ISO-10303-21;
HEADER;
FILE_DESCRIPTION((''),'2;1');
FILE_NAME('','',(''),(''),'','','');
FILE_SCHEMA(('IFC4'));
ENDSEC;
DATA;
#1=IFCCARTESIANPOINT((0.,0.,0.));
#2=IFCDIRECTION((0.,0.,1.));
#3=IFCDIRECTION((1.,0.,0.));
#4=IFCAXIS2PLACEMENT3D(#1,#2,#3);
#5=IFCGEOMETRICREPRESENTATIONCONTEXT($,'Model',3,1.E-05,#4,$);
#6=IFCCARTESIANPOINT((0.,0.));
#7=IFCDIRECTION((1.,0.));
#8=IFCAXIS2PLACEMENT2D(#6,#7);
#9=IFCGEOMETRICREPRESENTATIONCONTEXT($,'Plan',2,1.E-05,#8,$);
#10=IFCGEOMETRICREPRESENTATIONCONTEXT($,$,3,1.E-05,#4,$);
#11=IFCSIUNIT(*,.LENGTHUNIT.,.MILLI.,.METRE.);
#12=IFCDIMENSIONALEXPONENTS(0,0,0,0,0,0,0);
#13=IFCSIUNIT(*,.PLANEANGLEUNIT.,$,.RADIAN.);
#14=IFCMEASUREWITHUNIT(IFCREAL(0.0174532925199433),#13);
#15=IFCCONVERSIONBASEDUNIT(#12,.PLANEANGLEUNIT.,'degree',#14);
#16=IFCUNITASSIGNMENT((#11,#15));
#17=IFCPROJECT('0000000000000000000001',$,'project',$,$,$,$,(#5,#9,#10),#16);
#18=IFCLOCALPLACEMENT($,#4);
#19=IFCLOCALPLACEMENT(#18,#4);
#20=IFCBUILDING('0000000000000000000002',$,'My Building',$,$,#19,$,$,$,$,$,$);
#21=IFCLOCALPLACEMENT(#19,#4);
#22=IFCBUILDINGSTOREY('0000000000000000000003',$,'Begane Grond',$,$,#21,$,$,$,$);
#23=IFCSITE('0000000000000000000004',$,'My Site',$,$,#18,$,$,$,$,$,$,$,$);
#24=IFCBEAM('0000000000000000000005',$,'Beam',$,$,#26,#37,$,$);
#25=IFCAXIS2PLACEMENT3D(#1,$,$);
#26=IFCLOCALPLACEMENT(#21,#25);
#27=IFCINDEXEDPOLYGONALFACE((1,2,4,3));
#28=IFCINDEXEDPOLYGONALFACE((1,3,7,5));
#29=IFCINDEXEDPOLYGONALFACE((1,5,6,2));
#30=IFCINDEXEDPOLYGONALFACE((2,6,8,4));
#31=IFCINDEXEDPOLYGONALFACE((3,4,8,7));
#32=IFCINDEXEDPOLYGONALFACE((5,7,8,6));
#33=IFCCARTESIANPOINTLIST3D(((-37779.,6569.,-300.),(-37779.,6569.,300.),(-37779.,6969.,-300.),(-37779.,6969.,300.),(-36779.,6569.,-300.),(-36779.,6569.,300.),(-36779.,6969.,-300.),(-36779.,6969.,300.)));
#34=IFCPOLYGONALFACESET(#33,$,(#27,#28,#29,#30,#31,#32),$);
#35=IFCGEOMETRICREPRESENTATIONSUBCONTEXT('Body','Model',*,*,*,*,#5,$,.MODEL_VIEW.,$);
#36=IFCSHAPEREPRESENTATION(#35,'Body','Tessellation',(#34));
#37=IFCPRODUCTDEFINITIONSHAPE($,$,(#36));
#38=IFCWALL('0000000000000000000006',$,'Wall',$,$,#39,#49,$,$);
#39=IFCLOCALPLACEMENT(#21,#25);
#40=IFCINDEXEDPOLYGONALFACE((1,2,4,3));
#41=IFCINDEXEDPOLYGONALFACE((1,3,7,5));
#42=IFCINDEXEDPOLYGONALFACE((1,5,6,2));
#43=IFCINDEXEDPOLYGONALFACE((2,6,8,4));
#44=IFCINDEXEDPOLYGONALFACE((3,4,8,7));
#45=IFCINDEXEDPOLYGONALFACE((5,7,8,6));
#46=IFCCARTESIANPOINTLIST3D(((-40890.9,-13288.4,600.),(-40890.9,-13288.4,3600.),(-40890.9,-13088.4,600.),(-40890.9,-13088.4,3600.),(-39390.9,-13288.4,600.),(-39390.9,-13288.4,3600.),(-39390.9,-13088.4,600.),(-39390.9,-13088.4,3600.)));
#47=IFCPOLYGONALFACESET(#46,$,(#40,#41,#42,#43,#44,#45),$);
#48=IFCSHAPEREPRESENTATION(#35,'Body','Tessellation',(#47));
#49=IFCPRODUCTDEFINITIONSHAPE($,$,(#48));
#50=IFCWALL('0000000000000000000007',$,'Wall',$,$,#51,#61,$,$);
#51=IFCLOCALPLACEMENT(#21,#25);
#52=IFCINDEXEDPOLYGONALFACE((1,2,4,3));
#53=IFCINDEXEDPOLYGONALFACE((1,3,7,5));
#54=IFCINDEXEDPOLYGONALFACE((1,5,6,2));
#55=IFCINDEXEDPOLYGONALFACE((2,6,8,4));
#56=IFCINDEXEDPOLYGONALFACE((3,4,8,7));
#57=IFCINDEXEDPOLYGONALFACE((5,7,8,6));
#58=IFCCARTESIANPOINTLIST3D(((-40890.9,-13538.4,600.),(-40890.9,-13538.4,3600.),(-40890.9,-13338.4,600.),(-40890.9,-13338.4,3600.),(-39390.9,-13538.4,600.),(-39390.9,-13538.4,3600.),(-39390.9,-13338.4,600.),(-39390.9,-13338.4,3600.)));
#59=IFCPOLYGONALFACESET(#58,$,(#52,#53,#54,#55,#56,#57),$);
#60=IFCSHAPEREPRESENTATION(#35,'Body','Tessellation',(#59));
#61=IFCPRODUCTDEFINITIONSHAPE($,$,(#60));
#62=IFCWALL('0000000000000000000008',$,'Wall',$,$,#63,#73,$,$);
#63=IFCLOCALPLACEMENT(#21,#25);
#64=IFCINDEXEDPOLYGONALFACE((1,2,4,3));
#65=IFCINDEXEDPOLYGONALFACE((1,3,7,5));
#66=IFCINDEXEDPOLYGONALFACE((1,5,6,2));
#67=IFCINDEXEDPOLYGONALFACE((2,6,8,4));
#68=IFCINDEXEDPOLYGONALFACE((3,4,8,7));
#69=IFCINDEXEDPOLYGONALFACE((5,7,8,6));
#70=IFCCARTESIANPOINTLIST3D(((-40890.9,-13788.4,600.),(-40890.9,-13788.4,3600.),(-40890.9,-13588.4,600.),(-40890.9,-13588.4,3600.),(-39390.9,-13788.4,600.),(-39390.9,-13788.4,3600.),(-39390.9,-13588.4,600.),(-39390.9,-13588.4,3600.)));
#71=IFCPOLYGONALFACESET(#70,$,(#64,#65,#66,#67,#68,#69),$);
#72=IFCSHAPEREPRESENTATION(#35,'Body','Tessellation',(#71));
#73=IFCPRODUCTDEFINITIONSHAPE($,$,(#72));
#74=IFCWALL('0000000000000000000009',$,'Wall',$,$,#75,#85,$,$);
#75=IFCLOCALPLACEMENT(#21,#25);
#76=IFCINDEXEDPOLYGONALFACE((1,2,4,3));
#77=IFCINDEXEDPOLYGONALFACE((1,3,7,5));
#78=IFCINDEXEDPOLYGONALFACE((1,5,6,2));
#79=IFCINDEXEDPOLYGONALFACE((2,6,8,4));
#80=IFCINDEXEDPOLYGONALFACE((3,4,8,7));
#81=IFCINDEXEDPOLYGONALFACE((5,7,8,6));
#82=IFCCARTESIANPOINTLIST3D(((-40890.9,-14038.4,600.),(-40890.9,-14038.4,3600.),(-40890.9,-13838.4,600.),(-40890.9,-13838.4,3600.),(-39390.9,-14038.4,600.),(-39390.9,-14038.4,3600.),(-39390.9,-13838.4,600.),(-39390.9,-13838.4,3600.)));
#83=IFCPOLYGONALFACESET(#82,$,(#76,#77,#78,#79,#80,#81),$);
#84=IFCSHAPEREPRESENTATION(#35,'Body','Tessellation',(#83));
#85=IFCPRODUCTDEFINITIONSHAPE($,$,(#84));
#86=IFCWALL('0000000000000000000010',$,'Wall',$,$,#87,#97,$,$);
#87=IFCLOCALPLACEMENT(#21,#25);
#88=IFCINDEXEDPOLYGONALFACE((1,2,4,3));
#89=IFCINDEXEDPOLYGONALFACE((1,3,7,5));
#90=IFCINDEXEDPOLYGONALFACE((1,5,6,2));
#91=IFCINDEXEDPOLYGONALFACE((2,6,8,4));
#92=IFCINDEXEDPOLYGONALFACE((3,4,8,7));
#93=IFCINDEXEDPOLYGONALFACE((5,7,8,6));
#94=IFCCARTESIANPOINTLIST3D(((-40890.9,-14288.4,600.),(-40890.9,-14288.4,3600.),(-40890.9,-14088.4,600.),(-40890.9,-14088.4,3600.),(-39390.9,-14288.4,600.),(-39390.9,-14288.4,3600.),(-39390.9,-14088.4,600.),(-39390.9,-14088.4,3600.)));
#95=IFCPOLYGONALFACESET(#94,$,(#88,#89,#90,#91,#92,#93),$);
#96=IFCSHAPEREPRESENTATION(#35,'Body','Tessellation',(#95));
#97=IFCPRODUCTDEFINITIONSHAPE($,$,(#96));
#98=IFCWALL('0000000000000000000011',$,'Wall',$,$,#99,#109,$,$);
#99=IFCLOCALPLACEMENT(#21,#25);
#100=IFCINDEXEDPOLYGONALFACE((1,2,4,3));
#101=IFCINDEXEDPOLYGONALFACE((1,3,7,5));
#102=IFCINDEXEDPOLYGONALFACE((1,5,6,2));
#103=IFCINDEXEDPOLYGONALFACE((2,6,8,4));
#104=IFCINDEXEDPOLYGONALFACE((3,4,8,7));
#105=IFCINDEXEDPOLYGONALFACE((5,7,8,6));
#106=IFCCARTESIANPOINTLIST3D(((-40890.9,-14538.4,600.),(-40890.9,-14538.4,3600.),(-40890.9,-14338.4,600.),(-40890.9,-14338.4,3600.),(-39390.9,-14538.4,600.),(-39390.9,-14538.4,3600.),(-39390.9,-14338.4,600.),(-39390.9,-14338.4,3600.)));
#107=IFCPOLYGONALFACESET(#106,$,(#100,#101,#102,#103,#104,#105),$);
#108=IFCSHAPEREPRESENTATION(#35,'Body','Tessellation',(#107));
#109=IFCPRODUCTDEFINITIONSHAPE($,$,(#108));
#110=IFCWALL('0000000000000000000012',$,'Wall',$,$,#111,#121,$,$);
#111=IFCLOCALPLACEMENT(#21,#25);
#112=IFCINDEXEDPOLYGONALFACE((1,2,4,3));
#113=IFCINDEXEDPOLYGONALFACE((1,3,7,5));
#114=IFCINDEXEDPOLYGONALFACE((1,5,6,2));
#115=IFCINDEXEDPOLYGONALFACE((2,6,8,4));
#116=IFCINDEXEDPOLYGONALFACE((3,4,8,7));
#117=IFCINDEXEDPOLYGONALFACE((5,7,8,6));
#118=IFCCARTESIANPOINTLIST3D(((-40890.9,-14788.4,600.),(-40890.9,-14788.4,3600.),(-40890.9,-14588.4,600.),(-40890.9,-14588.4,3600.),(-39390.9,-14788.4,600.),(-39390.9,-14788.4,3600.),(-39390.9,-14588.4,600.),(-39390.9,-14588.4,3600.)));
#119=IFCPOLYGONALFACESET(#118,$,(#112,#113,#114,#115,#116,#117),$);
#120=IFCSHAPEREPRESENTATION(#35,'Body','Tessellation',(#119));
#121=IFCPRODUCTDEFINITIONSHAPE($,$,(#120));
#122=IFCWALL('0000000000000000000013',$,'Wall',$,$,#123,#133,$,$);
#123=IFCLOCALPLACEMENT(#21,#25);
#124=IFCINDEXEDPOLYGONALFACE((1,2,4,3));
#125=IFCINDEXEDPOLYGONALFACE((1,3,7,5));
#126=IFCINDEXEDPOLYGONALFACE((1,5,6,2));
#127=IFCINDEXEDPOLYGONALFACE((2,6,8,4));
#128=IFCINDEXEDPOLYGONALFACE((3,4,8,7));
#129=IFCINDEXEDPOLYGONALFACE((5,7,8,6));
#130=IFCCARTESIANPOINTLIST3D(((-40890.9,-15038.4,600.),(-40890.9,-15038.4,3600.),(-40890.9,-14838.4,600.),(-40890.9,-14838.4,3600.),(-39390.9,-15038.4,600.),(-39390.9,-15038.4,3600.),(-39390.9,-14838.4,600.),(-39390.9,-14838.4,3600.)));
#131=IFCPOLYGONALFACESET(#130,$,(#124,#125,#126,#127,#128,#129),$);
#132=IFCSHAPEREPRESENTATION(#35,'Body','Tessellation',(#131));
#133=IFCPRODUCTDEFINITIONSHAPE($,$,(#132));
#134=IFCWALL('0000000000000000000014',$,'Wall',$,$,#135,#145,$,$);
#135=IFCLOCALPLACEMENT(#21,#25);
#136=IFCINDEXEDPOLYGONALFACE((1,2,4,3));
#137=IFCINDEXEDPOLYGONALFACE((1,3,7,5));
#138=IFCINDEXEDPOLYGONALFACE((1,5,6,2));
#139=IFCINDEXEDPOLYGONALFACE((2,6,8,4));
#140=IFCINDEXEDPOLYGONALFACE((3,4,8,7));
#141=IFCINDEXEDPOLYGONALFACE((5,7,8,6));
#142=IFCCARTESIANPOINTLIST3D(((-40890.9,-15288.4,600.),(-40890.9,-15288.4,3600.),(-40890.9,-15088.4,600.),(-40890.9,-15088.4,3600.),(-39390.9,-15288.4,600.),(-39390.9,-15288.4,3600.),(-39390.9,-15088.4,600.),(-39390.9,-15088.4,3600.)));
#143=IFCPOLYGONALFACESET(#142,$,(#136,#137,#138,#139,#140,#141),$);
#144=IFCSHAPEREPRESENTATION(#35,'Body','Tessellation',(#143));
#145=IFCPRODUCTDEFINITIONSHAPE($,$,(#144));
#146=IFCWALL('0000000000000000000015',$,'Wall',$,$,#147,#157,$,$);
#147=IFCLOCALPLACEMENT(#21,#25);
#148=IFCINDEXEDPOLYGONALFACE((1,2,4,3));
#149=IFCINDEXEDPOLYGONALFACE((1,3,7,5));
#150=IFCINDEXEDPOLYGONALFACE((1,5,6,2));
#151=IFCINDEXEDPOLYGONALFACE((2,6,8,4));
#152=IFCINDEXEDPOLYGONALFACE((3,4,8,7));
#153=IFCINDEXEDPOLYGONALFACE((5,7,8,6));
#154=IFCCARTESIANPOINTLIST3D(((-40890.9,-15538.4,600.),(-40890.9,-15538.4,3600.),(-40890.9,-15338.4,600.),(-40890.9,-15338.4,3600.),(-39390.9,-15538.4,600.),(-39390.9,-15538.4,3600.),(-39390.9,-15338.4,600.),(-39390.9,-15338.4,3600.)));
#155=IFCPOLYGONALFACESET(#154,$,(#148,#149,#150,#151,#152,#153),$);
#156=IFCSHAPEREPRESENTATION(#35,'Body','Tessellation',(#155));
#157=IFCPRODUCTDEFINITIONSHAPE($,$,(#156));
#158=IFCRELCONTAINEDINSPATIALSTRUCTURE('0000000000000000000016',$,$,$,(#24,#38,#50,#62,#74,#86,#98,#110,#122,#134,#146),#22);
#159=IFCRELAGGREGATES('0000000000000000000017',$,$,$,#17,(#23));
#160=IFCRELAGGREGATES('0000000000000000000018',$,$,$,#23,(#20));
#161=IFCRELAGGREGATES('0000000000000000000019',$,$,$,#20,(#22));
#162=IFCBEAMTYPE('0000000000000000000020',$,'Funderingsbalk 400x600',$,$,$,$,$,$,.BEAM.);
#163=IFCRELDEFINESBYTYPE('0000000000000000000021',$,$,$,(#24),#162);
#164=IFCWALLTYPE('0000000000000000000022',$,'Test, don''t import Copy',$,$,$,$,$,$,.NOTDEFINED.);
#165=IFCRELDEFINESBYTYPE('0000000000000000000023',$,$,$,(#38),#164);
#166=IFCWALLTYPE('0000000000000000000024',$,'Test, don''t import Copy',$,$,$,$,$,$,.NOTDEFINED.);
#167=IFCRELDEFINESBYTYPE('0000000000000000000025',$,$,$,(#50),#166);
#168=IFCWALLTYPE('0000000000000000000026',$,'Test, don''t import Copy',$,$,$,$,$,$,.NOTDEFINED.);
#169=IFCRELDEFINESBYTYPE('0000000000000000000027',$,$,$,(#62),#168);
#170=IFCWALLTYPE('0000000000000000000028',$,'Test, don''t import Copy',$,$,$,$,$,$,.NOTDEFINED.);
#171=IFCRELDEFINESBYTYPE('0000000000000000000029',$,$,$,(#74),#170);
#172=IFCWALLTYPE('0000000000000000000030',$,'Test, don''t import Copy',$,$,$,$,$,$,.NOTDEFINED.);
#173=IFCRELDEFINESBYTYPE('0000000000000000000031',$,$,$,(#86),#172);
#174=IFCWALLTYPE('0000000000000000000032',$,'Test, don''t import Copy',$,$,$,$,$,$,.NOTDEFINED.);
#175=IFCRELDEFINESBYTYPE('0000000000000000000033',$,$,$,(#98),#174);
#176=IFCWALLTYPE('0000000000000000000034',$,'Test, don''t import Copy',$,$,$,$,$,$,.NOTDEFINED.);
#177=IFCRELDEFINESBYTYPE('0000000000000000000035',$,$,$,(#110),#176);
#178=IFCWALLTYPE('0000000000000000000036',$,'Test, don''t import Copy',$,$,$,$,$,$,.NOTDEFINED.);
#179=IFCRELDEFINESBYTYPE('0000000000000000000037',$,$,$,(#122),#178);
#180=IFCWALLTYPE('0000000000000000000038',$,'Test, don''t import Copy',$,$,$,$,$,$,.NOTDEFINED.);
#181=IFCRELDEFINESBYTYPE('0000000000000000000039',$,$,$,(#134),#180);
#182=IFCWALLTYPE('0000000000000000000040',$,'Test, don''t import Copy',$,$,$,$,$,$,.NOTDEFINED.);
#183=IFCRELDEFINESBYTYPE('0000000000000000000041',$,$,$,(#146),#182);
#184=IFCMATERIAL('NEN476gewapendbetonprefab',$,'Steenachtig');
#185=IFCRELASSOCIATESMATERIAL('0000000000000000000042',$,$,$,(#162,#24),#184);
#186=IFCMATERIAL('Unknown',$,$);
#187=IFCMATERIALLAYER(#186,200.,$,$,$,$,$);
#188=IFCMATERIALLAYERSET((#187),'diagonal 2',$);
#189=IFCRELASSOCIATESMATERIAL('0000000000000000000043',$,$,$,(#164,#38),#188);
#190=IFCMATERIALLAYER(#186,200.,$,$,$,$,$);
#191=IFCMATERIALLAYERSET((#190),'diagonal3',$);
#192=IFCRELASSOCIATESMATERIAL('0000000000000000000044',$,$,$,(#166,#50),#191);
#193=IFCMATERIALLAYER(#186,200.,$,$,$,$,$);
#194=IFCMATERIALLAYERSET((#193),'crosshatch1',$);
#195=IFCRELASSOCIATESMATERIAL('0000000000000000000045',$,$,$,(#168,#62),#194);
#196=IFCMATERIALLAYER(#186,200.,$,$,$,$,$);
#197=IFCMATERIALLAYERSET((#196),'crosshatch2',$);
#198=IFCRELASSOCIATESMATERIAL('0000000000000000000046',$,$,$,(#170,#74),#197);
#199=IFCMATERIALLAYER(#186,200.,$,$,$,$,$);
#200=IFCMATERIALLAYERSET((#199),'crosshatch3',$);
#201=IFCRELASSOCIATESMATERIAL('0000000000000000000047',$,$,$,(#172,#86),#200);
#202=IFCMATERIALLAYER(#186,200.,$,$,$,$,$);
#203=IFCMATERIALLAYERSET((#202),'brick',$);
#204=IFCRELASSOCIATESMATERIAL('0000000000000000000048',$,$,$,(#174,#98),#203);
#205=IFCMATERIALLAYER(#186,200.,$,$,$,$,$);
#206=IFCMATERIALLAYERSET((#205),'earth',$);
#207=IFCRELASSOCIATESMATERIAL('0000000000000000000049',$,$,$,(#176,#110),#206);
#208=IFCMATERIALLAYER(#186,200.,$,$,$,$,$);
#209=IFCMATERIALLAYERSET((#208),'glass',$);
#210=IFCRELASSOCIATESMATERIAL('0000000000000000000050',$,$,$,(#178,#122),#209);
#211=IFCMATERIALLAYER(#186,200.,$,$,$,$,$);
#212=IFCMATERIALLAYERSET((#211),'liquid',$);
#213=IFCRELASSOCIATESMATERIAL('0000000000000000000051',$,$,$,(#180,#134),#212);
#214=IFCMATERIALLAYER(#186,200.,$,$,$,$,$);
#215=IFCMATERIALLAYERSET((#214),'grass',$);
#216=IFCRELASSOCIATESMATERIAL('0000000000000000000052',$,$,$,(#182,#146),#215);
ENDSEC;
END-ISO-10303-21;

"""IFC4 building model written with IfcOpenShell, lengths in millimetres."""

from ifc_helpers import new_model, entity, si_unit, converted_unit, frame, origin_with_axes, origin_2d_with_axis, place, context, subcontext, project, spatial, indexed_curve, rectangle, outline, extrude, material, layer, layer_set, layer_usage, material_profile, profile_set, profile_usage, type_object, element, save


model = new_model("IFC4")

# Units and contexts
model_context = context("Model", 3, precision=1e-05, world=origin_with_axes())
plan_context = context("Plan", 2, precision=1e-05, world=origin_2d_with_axis())
context_of_model = context(None, 3, precision=1e-05, world=origin_with_axes())
body_context = subcontext(model_context, "Body", "Model", "MODEL_VIEW")
ifc_project = project(units=[si_unit("LENGTHUNIT", "METRE", prefix="MILLI"), converted_unit("PLANEANGLEUNIT", "degree", entity("IfcReal", 0.0174532925199433), si_unit("PLANEANGLEUNIT", "RADIAN"), dimensions=[0, 0, 0, 0, 0, 0, 0])], contexts=[model_context, plan_context, context_of_model])

# Site, building, storey
site_placement = place(None, frame((0.0, 0.0, 0.0), z_axis=(0.0, 0.0, 1.0), x_axis=(1.0, 0.0, 0.0)))
site = spatial("IfcSite", under=ifc_project, at=site_placement, Name="My Site")
building_placement = place(site_placement, origin_with_axes())
building = spatial("IfcBuilding", under=site, at=building_placement, Name="My Building")
storey_placement = place(building_placement, origin_with_axes())
storey = spatial("IfcBuildingStorey", under=building, at=storey_placement, Name="Begane Grond")

# Beam
ifc_material_1 = material(Name="NEN476gewapendbetonprefab", Category="Steenachtig")
ifc_material_profile_1 = material_profile(ifc_material_1, rectangle(XDim=400.0, YDim=600.0))
ifc_profile_set_1 = profile_set([ifc_material_profile_1], Name="gewapendbetonprefab")
ifc_profile_usage_1 = profile_usage(ifc_profile_set_1, cardinal=5)
beam_type_1 = type_object("IfcBeamType", Name="Funderingsbalk 400x600", PredefinedType="BEAM", material=ifc_profile_set_1)
beam_1_placement = place(storey_placement, frame((-37779.0, 6769.0, 0.0), z_axis=(1.0, 0.0, 0.0), x_axis=(0.0, 1.0, 0.0)))
element("IfcBeam", 1, at=beam_1_placement, inside=storey, type_object=beam_type_1, material=ifc_profile_usage_1, Name="Beam", context=body_context, shape_type="SweptSolid", body=[
    extrude(rectangle(XDim=400.0, YDim=600.0), origin_with_axes(), (0.0, 0.0, 1.0), 1000.0),
])

# Walls
ifc_material_2 = material(Name="Unknown")
ifc_layer_1 = layer(ifc_material_2, 200.0)
ifc_layer_set_1 = layer_set([ifc_layer_1], Name="diagonal 2")
ifc_layer_usage_1 = layer_usage(ifc_layer_set_1, "AXIS2", "POSITIVE", 0.0)
wall_type_1 = type_object("IfcWallType", Name="Test, don't import Copy", PredefinedType="NOTDEFINED", material=ifc_layer_set_1)
wall_1_placement = place(storey_placement, frame((-40890.9, -13288.4, 600.0), z_axis=(0.0, 0.0, 1.0), x_axis=(1.0, 0.0, 0.0)))
element("IfcWall", 2, at=wall_1_placement, inside=storey, type_object=wall_type_1, material=ifc_layer_usage_1, Name="Wall", context=body_context, shape_type="SweptSolid", body=[
    extrude(outline(indexed_curve([(0.0, 0.0), (0.0, 200.0), (1500.0, 200.0), (1500.0, 0.0), (0.0, 0.0)], self_intersect=False)), origin_with_axes(), (0.0, 0.0, 1.0), 3000.0),
])
ifc_layer_2 = layer(ifc_material_2, 200.0)
ifc_layer_set_2 = layer_set([ifc_layer_2], Name="diagonal3")
ifc_layer_usage_2 = layer_usage(ifc_layer_set_2, "AXIS2", "POSITIVE", 0.0)
wall_type_2 = type_object("IfcWallType", Name="Test, don't import Copy", PredefinedType="NOTDEFINED", material=ifc_layer_set_2)
wall_2_placement = place(storey_placement, frame((-40890.9, -13538.4, 600.0), z_axis=(0.0, 0.0, 1.0), x_axis=(1.0, 0.0, 0.0)))
element("IfcWall", 3, at=wall_2_placement, inside=storey, type_object=wall_type_2, material=ifc_layer_usage_2, Name="Wall", context=body_context, shape_type="SweptSolid", body=[
    extrude(outline(indexed_curve([(0.0, 0.0), (0.0, 200.0), (1500.0, 200.0), (1500.0, 0.0), (0.0, 0.0)], self_intersect=False)), origin_with_axes(), (0.0, 0.0, 1.0), 3000.0),
])
ifc_layer_3 = layer(ifc_material_2, 200.0)
ifc_layer_set_3 = layer_set([ifc_layer_3], Name="crosshatch1")
ifc_layer_usage_3 = layer_usage(ifc_layer_set_3, "AXIS2", "POSITIVE", 0.0)
wall_type_3 = type_object("IfcWallType", Name="Test, don't import Copy", PredefinedType="NOTDEFINED", material=ifc_layer_set_3)
wall_3_placement = place(storey_placement, frame((-40890.9, -13788.4, 600.0), z_axis=(0.0, 0.0, 1.0), x_axis=(1.0, 0.0, 0.0)))
element("IfcWall", 4, at=wall_3_placement, inside=storey, type_object=wall_type_3, material=ifc_layer_usage_3, Name="Wall", context=body_context, shape_type="SweptSolid", body=[
    extrude(outline(indexed_curve([(0.0, 0.0), (0.0, 200.0), (1500.0, 200.0), (1500.0, 0.0), (0.0, 0.0)], self_intersect=False)), origin_with_axes(), (0.0, 0.0, 1.0), 3000.0),
])
ifc_layer_4 = layer(ifc_material_2, 200.0)
ifc_layer_set_4 = layer_set([ifc_layer_4], Name="crosshatch2")
ifc_layer_usage_4 = layer_usage(ifc_layer_set_4, "AXIS2", "POSITIVE", 0.0)
wall_type_4 = type_object("IfcWallType", Name="Test, don't import Copy", PredefinedType="NOTDEFINED", material=ifc_layer_set_4)
wall_4_placement = place(storey_placement, frame((-40890.9, -14038.4, 600.0), z_axis=(0.0, 0.0, 1.0), x_axis=(1.0, 0.0, 0.0)))
element("IfcWall", 5, at=wall_4_placement, inside=storey, type_object=wall_type_4, material=ifc_layer_usage_4, Name="Wall", context=body_context, shape_type="SweptSolid", body=[
    extrude(outline(indexed_curve([(0.0, 0.0), (0.0, 200.0), (1500.0, 200.0), (1500.0, 0.0), (0.0, 0.0)], self_intersect=False)), origin_with_axes(), (0.0, 0.0, 1.0), 3000.0),
])
ifc_layer_5 = layer(ifc_material_2, 200.0)
ifc_layer_set_5 = layer_set([ifc_layer_5], Name="crosshatch3")
ifc_layer_usage_5 = layer_usage(ifc_layer_set_5, "AXIS2", "POSITIVE", 0.0)
wall_type_5 = type_object("IfcWallType", Name="Test, don't import Copy", PredefinedType="NOTDEFINED", material=ifc_layer_set_5)
wall_5_placement = place(storey_placement, frame((-40890.9, -14288.4, 600.0), z_axis=(0.0, 0.0, 1.0), x_axis=(1.0, 0.0, 0.0)))
element("IfcWall", 6, at=wall_5_placement, inside=storey, type_object=wall_type_5, material=ifc_layer_usage_5, Name="Wall", context=body_context, shape_type="SweptSolid", body=[
    extrude(outline(indexed_curve([(0.0, 0.0), (0.0, 200.0), (1500.0, 200.0), (1500.0, 0.0), (0.0, 0.0)], self_intersect=False)), origin_with_axes(), (0.0, 0.0, 1.0), 3000.0),
])
ifc_layer_6 = layer(ifc_material_2, 200.0)
ifc_layer_set_6 = layer_set([ifc_layer_6], Name="brick")
ifc_layer_usage_6 = layer_usage(ifc_layer_set_6, "AXIS2", "POSITIVE", 0.0)
wall_type_6 = type_object("IfcWallType", Name="Test, don't import Copy", PredefinedType="NOTDEFINED", material=ifc_layer_set_6)
wall_6_placement = place(storey_placement, frame((-40890.9, -14538.4, 600.0), z_axis=(0.0, 0.0, 1.0), x_axis=(1.0, 0.0, 0.0)))
element("IfcWall", 7, at=wall_6_placement, inside=storey, type_object=wall_type_6, material=ifc_layer_usage_6, Name="Wall", context=body_context, shape_type="SweptSolid", body=[
    extrude(outline(indexed_curve([(0.0, 0.0), (0.0, 200.0), (1500.0, 200.0), (1500.0, 0.0), (0.0, 0.0)], self_intersect=False)), origin_with_axes(), (0.0, 0.0, 1.0), 3000.0),
])
ifc_layer_7 = layer(ifc_material_2, 200.0)
ifc_layer_set_7 = layer_set([ifc_layer_7], Name="earth")
ifc_layer_usage_7 = layer_usage(ifc_layer_set_7, "AXIS2", "POSITIVE", 0.0)
wall_type_7 = type_object("IfcWallType", Name="Test, don't import Copy", PredefinedType="NOTDEFINED", material=ifc_layer_set_7)
wall_7_placement = place(storey_placement, frame((-40890.9, -14788.4, 600.0), z_axis=(0.0, 0.0, 1.0), x_axis=(1.0, 0.0, 0.0)))
element("IfcWall", 8, at=wall_7_placement, inside=storey, type_object=wall_type_7, material=ifc_layer_usage_7, Name="Wall", context=body_context, shape_type="SweptSolid", body=[
    extrude(outline(indexed_curve([(0.0, 0.0), (0.0, 200.0), (1500.0, 200.0), (1500.0, 0.0), (0.0, 0.0)], self_intersect=False)), origin_with_axes(), (0.0, 0.0, 1.0), 3000.0),
])
ifc_layer_8 = layer(ifc_material_2, 200.0)
ifc_layer_set_8 = layer_set([ifc_layer_8], Name="glass")
ifc_layer_usage_8 = layer_usage(ifc_layer_set_8, "AXIS2", "POSITIVE", 0.0)
wall_type_8 = type_object("IfcWallType", Name="Test, don't import Copy", PredefinedType="NOTDEFINED", material=ifc_layer_set_8)
wall_8_placement = place(storey_placement, frame((-40890.9, -15038.4, 600.0), z_axis=(0.0, 0.0, 1.0), x_axis=(1.0, 0.0, 0.0)))
element("IfcWall", 9, at=wall_8_placement, inside=storey, type_object=wall_type_8, material=ifc_layer_usage_8, Name="Wall", context=body_context, shape_type="SweptSolid", body=[
    extrude(outline(indexed_curve([(0.0, 0.0), (0.0, 200.0), (1500.0, 200.0), (1500.0, 0.0), (0.0, 0.0)], self_intersect=False)), origin_with_axes(), (0.0, 0.0, 1.0), 3000.0),
])
ifc_layer_9 = layer(ifc_material_2, 200.0)
ifc_layer_set_9 = layer_set([ifc_layer_9], Name="liquid")
ifc_layer_usage_9 = layer_usage(ifc_layer_set_9, "AXIS2", "POSITIVE", 0.0)
wall_type_9 = type_object("IfcWallType", Name="Test, don't import Copy", PredefinedType="NOTDEFINED", material=ifc_layer_set_9)
wall_9_placement = place(storey_placement, frame((-40890.9, -15288.4, 600.0), z_axis=(0.0, 0.0, 1.0), x_axis=(1.0, 0.0, 0.0)))
element("IfcWall", 10, at=wall_9_placement, inside=storey, type_object=wall_type_9, material=ifc_layer_usage_9, Name="Wall", context=body_context, shape_type="SweptSolid", body=[
    extrude(outline(indexed_curve([(0.0, 0.0), (0.0, 200.0), (1500.0, 200.0), (1500.0, 0.0), (0.0, 0.0)], self_intersect=False)), origin_with_axes(), (0.0, 0.0, 1.0), 3000.0),
])
ifc_layer_10 = layer(ifc_material_2, 200.0)
ifc_layer_set_10 = layer_set([ifc_layer_10], Name="grass")
ifc_layer_usage_10 = layer_usage(ifc_layer_set_10, "AXIS2", "POSITIVE", 0.0)
wall_type_10 = type_object("IfcWallType", Name="Test, don't import Copy", PredefinedType="NOTDEFINED", material=ifc_layer_set_10)
wall_10_placement = place(storey_placement, frame((-40890.9, -15538.4, 600.0), z_axis=(0.0, 0.0, 1.0), x_axis=(1.0, 0.0, 0.0)))
element("IfcWall", 11, at=wall_10_placement, inside=storey, type_object=wall_type_10, material=ifc_layer_usage_10, Name="Wall", context=body_context, shape_type="SweptSolid", body=[
    extrude(outline(indexed_curve([(0.0, 0.0), (0.0, 200.0), (1500.0, 200.0), (1500.0, 0.0), (0.0, 0.0)], self_intersect=False)), origin_with_axes(), (0.0, 0.0, 1.0), 3000.0),
])

save(model, "model.ifc")
